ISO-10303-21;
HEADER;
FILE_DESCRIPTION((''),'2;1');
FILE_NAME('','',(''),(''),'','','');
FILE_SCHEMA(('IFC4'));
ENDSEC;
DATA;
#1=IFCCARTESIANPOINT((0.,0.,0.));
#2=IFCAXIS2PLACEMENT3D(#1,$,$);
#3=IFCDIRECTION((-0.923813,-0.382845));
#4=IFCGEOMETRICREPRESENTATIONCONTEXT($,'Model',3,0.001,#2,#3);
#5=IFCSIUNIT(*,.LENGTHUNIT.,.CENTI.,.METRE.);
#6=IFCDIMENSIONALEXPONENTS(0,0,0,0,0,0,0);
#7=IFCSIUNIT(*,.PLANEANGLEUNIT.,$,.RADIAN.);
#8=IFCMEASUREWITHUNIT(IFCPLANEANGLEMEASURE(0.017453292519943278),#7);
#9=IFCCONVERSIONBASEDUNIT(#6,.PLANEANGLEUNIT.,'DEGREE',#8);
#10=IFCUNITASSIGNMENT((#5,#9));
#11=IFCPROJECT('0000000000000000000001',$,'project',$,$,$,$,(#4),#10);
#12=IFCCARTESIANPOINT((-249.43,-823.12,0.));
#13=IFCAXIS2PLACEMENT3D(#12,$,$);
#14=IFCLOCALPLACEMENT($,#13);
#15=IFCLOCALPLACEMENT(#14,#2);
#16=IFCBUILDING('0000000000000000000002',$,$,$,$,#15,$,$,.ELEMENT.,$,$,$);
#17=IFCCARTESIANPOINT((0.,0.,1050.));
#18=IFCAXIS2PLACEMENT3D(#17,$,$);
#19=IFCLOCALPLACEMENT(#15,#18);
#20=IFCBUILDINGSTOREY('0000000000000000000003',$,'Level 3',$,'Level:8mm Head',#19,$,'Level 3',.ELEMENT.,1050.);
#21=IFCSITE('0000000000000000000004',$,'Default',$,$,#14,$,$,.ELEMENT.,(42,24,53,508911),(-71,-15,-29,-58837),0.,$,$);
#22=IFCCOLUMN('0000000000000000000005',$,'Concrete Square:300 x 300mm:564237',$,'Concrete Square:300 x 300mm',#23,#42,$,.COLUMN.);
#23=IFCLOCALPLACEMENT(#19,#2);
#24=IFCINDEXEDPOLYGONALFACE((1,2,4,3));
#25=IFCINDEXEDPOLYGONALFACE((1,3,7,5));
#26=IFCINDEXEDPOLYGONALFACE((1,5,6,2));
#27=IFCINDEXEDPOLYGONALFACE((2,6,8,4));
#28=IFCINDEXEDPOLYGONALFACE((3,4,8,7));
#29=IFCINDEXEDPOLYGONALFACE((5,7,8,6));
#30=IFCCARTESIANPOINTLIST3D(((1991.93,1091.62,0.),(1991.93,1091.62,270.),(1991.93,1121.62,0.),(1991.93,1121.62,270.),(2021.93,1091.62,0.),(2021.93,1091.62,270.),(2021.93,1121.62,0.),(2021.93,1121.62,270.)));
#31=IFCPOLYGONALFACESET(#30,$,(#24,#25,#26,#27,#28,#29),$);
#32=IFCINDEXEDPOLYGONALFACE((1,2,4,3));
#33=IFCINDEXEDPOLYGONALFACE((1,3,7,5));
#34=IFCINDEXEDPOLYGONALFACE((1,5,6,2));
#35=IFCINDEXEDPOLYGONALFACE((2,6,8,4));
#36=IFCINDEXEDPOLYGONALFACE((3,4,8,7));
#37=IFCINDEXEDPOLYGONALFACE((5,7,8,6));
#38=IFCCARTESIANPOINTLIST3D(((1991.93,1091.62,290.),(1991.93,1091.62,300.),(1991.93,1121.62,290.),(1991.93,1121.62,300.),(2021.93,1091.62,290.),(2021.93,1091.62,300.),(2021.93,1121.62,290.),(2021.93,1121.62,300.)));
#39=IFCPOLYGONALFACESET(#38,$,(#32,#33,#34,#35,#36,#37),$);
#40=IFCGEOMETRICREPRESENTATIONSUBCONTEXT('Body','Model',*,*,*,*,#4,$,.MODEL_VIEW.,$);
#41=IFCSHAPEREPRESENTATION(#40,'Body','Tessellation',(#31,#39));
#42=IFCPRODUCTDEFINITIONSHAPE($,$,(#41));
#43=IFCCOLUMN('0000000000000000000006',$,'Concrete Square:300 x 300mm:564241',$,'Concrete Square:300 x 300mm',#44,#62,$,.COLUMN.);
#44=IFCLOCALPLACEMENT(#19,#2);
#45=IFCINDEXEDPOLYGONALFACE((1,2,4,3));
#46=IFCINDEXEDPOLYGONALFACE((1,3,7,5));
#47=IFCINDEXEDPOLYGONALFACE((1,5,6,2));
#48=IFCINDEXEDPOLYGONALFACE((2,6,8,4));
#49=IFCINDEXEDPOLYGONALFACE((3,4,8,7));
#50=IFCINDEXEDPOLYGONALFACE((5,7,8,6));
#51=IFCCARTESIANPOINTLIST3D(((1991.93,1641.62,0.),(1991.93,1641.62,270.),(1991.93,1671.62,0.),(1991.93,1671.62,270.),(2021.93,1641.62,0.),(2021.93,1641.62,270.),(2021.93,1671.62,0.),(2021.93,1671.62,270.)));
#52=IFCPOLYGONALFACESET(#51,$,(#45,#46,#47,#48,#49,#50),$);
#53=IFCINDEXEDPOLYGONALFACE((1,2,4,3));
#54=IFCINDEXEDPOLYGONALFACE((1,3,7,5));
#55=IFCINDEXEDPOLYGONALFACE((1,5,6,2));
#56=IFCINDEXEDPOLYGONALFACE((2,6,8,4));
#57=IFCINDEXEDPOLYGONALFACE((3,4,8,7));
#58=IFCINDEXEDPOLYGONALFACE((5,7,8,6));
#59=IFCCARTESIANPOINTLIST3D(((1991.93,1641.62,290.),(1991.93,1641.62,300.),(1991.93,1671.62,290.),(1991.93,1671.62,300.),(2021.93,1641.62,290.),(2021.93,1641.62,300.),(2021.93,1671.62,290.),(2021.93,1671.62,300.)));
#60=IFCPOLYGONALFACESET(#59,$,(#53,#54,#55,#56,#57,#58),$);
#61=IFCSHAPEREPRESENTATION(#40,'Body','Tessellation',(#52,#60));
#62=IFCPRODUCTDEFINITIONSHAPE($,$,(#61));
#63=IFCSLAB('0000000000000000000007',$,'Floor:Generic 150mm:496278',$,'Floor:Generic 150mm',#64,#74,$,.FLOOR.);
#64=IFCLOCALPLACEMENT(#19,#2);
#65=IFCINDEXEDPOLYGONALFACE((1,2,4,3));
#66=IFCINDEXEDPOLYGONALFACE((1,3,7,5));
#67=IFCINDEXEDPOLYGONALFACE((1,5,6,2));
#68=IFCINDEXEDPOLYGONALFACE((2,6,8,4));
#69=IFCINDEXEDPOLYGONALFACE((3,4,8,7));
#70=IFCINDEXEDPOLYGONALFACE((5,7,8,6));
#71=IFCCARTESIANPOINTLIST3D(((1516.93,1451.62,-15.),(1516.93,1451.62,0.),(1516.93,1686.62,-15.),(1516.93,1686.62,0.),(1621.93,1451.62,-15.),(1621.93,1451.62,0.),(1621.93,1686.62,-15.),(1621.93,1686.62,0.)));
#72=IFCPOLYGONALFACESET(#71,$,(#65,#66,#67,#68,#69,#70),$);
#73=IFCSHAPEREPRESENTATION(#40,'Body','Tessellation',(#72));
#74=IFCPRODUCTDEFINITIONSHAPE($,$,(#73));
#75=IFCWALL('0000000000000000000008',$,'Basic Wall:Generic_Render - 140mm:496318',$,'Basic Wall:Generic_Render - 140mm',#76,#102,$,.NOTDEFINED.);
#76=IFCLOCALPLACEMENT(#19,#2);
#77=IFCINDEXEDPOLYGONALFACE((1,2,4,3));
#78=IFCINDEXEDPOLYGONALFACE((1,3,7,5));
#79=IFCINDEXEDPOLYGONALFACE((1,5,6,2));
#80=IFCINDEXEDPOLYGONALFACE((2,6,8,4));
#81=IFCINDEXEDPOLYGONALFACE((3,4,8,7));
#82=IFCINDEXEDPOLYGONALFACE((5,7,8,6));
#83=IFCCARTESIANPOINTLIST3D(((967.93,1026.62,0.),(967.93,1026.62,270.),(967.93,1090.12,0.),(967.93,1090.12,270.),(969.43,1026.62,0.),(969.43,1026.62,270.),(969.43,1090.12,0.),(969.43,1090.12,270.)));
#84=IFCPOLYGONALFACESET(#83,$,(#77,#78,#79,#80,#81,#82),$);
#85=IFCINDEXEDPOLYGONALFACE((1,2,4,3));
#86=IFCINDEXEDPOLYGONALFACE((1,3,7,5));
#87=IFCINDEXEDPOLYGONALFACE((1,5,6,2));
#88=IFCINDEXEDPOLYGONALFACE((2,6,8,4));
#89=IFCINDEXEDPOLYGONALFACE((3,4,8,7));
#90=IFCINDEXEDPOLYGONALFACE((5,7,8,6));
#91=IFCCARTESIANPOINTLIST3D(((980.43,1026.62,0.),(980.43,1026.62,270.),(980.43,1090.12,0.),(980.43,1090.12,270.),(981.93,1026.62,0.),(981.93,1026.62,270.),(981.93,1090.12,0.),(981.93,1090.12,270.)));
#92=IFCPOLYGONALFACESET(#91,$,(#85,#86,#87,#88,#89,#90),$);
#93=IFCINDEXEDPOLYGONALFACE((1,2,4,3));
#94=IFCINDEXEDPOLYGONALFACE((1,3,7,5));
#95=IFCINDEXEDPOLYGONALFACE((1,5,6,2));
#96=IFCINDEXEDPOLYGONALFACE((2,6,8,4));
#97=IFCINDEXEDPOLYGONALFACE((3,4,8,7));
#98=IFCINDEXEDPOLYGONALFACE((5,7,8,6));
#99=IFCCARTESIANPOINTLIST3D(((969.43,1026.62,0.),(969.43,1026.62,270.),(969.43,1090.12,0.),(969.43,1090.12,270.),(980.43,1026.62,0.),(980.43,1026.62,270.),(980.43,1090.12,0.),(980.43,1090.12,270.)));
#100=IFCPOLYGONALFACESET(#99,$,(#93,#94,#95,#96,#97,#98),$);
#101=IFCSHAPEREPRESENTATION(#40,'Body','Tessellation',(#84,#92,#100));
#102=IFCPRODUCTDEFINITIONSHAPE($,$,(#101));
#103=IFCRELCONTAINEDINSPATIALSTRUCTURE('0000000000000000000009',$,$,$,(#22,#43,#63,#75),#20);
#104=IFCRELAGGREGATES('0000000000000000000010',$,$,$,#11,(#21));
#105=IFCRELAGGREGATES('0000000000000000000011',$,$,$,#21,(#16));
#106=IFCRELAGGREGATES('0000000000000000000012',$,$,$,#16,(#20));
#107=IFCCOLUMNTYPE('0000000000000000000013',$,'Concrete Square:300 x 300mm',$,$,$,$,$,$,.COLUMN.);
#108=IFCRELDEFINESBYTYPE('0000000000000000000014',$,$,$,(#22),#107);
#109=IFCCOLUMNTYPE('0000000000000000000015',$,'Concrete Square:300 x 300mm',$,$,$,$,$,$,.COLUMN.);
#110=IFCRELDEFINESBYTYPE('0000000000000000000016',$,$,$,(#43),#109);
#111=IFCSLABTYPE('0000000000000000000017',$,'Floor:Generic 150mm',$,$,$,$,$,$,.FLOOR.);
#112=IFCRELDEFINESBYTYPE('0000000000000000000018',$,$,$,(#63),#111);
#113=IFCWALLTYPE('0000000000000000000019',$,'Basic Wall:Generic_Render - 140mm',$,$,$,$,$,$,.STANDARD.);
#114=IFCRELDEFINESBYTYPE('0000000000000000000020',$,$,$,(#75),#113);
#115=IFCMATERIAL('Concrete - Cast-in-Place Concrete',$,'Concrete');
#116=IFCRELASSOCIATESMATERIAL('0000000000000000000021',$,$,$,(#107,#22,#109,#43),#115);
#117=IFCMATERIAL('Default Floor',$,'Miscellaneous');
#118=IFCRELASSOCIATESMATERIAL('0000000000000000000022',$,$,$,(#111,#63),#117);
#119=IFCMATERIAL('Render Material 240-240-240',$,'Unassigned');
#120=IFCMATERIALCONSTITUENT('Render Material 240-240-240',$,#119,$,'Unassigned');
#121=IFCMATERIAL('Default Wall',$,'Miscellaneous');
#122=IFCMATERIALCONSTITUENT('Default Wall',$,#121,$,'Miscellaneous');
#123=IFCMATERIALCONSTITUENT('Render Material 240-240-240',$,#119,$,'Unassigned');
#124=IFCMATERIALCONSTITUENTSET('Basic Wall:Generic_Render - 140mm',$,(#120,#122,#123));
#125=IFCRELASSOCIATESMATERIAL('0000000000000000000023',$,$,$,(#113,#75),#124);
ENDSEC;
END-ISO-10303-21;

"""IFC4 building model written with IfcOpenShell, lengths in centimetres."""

from ifc_helpers import new_model, entity, si_unit, converted_unit, direction, frame, origin, place, context, subcontext, project, spatial, indexed_curve, outline, extrude, source, transform, mapped, material, constituent, constituent_set, type_object, type_shapes, element, save


model = new_model("IFC4")

# Units and contexts
model_context = context("Model", 3, precision=0.001, world=origin(), true_north=direction((-0.923813, -0.382845)))
body_context = subcontext(model_context, "Body", "Model", "MODEL_VIEW")
ifc_project = project(units=[si_unit("LENGTHUNIT", "METRE", prefix="CENTI"), converted_unit("PLANEANGLEUNIT", "DEGREE", entity("IfcPlaneAngleMeasure", 0.017453292519943278), si_unit("PLANEANGLEUNIT", "RADIAN"), dimensions=[0, 0, 0, 0, 0, 0, 0])], contexts=[model_context])

# Site, building, storey
site_placement = place(None, frame((-249.43, -823.12, 0.0)))
site = spatial("IfcSite", under=ifc_project, at=site_placement, Name="Default", CompositionType="ELEMENT", RefLatitude=(42, 24, 53, 508911), RefLongitude=(-71, -15, -29, -58837), RefElevation=0.0)
building_placement = place(site_placement, origin())
building = spatial("IfcBuilding", under=site, at=building_placement, CompositionType="ELEMENT")
storey_placement = place(building_placement, frame((0.0, 0.0, 1050.0)))
storey = spatial("IfcBuildingStorey", under=building, at=storey_placement, Name="Level 3", ObjectType="Level:8mm Head", LongName="Level 3", CompositionType="ELEMENT", Elevation=1050.0)

# Columns
ifc_material_1 = material(Name="Concrete - Cast-in-Place Concrete", Category="Concrete")
column_type_1 = type_object("IfcColumnType", Name="Concrete Square:300 x 300mm", PredefinedType="COLUMN", material=ifc_material_1)
shared_shape_1 = source(origin(), body_context, "Body", "SweptSolid", [
    extrude(outline(indexed_curve([(-15.0, -15.0), (15.0, -15.0), (15.0, 15.0), (-15.0, 15.0), (-15.0, -15.0)], self_intersect=False)), frame((2006.93, 1106.62, 1050.0), z_axis=(0.0, 0.0, 1.0), x_axis=(-1.0, 0.0, 0.0)), (0.0, 0.0, 1.0), 270.0),
    extrude(outline(indexed_curve([(-15.0, -15.0), (15.0, -15.0), (15.0, 15.0), (-15.0, 15.0), (-15.0, -15.0)], self_intersect=False)), frame((2006.93, 1106.62, 1340.0), z_axis=(0.0, 0.0, 1.0), x_axis=(-1.0, 0.0, 0.0)), (0.0, 0.0, 1.0), 10.0),
])
type_shapes(column_type_1, [shared_shape_1])
column_1_placement = place(storey_placement, frame((0.0, 0.0, -1050.0)))
element("IfcColumn", 1, at=column_1_placement, inside=storey, type_object=column_type_1, material=ifc_material_1, Name="Concrete Square:300 x 300mm:564237", ObjectType="Concrete Square:300 x 300mm", PredefinedType="COLUMN", context=body_context, shape_type="MappedRepresentation", body=[
    mapped(shared_shape_1, transform((0.0, 0.0, 0.0), scale=1.0)),
])
column_type_2 = type_object("IfcColumnType", Name="Concrete Square:300 x 300mm", PredefinedType="COLUMN", material=ifc_material_1)
shared_shape_2 = source(origin(), body_context, "Body", "SweptSolid", [
    extrude(outline(indexed_curve([(-15.0, -15.0), (15.0, -15.0), (15.0, 15.0), (-15.0, 15.0), (-15.0, -15.0)], self_intersect=False)), frame((2006.93, 1656.62, 1050.0), z_axis=(0.0, 0.0, 1.0), x_axis=(-1.0, 0.0, 0.0)), (0.0, 0.0, 1.0), 270.0),
    extrude(outline(indexed_curve([(-15.0, -15.0), (15.0, -15.0), (15.0, 15.0), (-15.0, 15.0), (-15.0, -15.0)], self_intersect=False)), frame((2006.93, 1656.62, 1340.0), z_axis=(0.0, 0.0, 1.0), x_axis=(-1.0, 0.0, 0.0)), (0.0, 0.0, 1.0), 10.0),
])
type_shapes(column_type_2, [shared_shape_2])
column_2_placement = place(storey_placement, frame((0.0, 0.0, -1050.0)))
element("IfcColumn", 2, at=column_2_placement, inside=storey, type_object=column_type_2, material=ifc_material_1, Name="Concrete Square:300 x 300mm:564241", ObjectType="Concrete Square:300 x 300mm", PredefinedType="COLUMN", context=body_context, shape_type="MappedRepresentation", body=[
    mapped(shared_shape_2, transform((0.0, 0.0, 0.0), scale=1.0)),
])

# Slab
ifc_material_2 = material(Name="Default Floor", Category="Miscellaneous")
slab_type_1 = type_object("IfcSlabType", Name="Floor:Generic 150mm", PredefinedType="FLOOR", material=ifc_material_2)
slab_1_placement = place(storey_placement, origin())
element("IfcSlab", 3, at=slab_1_placement, inside=storey, type_object=slab_type_1, material=ifc_material_2, Name="Floor:Generic 150mm:496278", ObjectType="Floor:Generic 150mm", PredefinedType="FLOOR", context=body_context, shape_type="SweptSolid", body=[
    extrude(outline(indexed_curve([(-117.5, -52.5), (117.5, -52.5), (117.5, 52.5), (-117.5, 52.5), (-117.5, -52.5)], self_intersect=False)), frame((1569.43, 1569.12, 0.0), z_axis=(0.0, 0.0, -1.0), x_axis=(0.0, 1.0, 0.0)), (0.0, 0.0, 1.0), 15.0),
])

# Wall
ifc_material_3 = material(Name="Render Material 240-240-240", Category="Unassigned")
ifc_constituent_1 = constituent(ifc_material_3, Name="Render Material 240-240-240", Category="Unassigned")
ifc_material_4 = material(Name="Default Wall", Category="Miscellaneous")
ifc_constituent_2 = constituent(ifc_material_4, Name="Default Wall", Category="Miscellaneous")
ifc_constituent_3 = constituent(ifc_material_3, Name="Render Material 240-240-240", Category="Unassigned")
ifc_constituent_set_1 = constituent_set(constituents=[ifc_constituent_1, ifc_constituent_2, ifc_constituent_3], Name="Basic Wall:Generic_Render - 140mm")
wall_type_1 = type_object("IfcWallType", Name="Basic Wall:Generic_Render - 140mm", PredefinedType="STANDARD", material=ifc_constituent_set_1)
wall_1_placement = place(storey_placement, frame((974.93, 1090.12, 0.0), z_axis=(0.0, 0.0, 1.0), x_axis=(0.0, -1.0, 0.0)))
element("IfcWall", 4, at=wall_1_placement, inside=storey, type_object=wall_type_1, material=ifc_constituent_set_1, Name="Basic Wall:Generic_Render - 140mm:496318", ObjectType="Basic Wall:Generic_Render - 140mm", PredefinedType="NOTDEFINED", context=body_context, shape_type="SweptSolid", body=[
    extrude(outline(indexed_curve([(-0.75, -31.75), (0.75, -31.75), (0.75, 31.75), (-0.75, 31.75), (-0.75, -31.75)], self_intersect=False)), frame((31.75, -6.25, 0.0), z_axis=(0.0, 0.0, 1.0), x_axis=(0.0, 1.0, 0.0)), (0.0, 0.0, 1.0), 270.0),
    extrude(outline(indexed_curve([(-0.75, -31.75), (0.75, -31.75), (0.75, 31.75), (-0.75, 31.75), (-0.75, -31.75)], self_intersect=False)), frame((31.75, 6.25, 0.0), z_axis=(0.0, 0.0, 1.0), x_axis=(0.0, -1.0, 0.0)), (0.0, 0.0, 1.0), 270.0),
    extrude(outline(indexed_curve([(-31.75, -5.5), (31.75, -5.5), (31.75, 5.5), (-31.75, 5.5), (-31.75, -5.5)], self_intersect=False)), frame((31.75, 0.0, 0.0)), (0.0, 0.0, 1.0), 270.0),
])

save(model, "model.ifc")
